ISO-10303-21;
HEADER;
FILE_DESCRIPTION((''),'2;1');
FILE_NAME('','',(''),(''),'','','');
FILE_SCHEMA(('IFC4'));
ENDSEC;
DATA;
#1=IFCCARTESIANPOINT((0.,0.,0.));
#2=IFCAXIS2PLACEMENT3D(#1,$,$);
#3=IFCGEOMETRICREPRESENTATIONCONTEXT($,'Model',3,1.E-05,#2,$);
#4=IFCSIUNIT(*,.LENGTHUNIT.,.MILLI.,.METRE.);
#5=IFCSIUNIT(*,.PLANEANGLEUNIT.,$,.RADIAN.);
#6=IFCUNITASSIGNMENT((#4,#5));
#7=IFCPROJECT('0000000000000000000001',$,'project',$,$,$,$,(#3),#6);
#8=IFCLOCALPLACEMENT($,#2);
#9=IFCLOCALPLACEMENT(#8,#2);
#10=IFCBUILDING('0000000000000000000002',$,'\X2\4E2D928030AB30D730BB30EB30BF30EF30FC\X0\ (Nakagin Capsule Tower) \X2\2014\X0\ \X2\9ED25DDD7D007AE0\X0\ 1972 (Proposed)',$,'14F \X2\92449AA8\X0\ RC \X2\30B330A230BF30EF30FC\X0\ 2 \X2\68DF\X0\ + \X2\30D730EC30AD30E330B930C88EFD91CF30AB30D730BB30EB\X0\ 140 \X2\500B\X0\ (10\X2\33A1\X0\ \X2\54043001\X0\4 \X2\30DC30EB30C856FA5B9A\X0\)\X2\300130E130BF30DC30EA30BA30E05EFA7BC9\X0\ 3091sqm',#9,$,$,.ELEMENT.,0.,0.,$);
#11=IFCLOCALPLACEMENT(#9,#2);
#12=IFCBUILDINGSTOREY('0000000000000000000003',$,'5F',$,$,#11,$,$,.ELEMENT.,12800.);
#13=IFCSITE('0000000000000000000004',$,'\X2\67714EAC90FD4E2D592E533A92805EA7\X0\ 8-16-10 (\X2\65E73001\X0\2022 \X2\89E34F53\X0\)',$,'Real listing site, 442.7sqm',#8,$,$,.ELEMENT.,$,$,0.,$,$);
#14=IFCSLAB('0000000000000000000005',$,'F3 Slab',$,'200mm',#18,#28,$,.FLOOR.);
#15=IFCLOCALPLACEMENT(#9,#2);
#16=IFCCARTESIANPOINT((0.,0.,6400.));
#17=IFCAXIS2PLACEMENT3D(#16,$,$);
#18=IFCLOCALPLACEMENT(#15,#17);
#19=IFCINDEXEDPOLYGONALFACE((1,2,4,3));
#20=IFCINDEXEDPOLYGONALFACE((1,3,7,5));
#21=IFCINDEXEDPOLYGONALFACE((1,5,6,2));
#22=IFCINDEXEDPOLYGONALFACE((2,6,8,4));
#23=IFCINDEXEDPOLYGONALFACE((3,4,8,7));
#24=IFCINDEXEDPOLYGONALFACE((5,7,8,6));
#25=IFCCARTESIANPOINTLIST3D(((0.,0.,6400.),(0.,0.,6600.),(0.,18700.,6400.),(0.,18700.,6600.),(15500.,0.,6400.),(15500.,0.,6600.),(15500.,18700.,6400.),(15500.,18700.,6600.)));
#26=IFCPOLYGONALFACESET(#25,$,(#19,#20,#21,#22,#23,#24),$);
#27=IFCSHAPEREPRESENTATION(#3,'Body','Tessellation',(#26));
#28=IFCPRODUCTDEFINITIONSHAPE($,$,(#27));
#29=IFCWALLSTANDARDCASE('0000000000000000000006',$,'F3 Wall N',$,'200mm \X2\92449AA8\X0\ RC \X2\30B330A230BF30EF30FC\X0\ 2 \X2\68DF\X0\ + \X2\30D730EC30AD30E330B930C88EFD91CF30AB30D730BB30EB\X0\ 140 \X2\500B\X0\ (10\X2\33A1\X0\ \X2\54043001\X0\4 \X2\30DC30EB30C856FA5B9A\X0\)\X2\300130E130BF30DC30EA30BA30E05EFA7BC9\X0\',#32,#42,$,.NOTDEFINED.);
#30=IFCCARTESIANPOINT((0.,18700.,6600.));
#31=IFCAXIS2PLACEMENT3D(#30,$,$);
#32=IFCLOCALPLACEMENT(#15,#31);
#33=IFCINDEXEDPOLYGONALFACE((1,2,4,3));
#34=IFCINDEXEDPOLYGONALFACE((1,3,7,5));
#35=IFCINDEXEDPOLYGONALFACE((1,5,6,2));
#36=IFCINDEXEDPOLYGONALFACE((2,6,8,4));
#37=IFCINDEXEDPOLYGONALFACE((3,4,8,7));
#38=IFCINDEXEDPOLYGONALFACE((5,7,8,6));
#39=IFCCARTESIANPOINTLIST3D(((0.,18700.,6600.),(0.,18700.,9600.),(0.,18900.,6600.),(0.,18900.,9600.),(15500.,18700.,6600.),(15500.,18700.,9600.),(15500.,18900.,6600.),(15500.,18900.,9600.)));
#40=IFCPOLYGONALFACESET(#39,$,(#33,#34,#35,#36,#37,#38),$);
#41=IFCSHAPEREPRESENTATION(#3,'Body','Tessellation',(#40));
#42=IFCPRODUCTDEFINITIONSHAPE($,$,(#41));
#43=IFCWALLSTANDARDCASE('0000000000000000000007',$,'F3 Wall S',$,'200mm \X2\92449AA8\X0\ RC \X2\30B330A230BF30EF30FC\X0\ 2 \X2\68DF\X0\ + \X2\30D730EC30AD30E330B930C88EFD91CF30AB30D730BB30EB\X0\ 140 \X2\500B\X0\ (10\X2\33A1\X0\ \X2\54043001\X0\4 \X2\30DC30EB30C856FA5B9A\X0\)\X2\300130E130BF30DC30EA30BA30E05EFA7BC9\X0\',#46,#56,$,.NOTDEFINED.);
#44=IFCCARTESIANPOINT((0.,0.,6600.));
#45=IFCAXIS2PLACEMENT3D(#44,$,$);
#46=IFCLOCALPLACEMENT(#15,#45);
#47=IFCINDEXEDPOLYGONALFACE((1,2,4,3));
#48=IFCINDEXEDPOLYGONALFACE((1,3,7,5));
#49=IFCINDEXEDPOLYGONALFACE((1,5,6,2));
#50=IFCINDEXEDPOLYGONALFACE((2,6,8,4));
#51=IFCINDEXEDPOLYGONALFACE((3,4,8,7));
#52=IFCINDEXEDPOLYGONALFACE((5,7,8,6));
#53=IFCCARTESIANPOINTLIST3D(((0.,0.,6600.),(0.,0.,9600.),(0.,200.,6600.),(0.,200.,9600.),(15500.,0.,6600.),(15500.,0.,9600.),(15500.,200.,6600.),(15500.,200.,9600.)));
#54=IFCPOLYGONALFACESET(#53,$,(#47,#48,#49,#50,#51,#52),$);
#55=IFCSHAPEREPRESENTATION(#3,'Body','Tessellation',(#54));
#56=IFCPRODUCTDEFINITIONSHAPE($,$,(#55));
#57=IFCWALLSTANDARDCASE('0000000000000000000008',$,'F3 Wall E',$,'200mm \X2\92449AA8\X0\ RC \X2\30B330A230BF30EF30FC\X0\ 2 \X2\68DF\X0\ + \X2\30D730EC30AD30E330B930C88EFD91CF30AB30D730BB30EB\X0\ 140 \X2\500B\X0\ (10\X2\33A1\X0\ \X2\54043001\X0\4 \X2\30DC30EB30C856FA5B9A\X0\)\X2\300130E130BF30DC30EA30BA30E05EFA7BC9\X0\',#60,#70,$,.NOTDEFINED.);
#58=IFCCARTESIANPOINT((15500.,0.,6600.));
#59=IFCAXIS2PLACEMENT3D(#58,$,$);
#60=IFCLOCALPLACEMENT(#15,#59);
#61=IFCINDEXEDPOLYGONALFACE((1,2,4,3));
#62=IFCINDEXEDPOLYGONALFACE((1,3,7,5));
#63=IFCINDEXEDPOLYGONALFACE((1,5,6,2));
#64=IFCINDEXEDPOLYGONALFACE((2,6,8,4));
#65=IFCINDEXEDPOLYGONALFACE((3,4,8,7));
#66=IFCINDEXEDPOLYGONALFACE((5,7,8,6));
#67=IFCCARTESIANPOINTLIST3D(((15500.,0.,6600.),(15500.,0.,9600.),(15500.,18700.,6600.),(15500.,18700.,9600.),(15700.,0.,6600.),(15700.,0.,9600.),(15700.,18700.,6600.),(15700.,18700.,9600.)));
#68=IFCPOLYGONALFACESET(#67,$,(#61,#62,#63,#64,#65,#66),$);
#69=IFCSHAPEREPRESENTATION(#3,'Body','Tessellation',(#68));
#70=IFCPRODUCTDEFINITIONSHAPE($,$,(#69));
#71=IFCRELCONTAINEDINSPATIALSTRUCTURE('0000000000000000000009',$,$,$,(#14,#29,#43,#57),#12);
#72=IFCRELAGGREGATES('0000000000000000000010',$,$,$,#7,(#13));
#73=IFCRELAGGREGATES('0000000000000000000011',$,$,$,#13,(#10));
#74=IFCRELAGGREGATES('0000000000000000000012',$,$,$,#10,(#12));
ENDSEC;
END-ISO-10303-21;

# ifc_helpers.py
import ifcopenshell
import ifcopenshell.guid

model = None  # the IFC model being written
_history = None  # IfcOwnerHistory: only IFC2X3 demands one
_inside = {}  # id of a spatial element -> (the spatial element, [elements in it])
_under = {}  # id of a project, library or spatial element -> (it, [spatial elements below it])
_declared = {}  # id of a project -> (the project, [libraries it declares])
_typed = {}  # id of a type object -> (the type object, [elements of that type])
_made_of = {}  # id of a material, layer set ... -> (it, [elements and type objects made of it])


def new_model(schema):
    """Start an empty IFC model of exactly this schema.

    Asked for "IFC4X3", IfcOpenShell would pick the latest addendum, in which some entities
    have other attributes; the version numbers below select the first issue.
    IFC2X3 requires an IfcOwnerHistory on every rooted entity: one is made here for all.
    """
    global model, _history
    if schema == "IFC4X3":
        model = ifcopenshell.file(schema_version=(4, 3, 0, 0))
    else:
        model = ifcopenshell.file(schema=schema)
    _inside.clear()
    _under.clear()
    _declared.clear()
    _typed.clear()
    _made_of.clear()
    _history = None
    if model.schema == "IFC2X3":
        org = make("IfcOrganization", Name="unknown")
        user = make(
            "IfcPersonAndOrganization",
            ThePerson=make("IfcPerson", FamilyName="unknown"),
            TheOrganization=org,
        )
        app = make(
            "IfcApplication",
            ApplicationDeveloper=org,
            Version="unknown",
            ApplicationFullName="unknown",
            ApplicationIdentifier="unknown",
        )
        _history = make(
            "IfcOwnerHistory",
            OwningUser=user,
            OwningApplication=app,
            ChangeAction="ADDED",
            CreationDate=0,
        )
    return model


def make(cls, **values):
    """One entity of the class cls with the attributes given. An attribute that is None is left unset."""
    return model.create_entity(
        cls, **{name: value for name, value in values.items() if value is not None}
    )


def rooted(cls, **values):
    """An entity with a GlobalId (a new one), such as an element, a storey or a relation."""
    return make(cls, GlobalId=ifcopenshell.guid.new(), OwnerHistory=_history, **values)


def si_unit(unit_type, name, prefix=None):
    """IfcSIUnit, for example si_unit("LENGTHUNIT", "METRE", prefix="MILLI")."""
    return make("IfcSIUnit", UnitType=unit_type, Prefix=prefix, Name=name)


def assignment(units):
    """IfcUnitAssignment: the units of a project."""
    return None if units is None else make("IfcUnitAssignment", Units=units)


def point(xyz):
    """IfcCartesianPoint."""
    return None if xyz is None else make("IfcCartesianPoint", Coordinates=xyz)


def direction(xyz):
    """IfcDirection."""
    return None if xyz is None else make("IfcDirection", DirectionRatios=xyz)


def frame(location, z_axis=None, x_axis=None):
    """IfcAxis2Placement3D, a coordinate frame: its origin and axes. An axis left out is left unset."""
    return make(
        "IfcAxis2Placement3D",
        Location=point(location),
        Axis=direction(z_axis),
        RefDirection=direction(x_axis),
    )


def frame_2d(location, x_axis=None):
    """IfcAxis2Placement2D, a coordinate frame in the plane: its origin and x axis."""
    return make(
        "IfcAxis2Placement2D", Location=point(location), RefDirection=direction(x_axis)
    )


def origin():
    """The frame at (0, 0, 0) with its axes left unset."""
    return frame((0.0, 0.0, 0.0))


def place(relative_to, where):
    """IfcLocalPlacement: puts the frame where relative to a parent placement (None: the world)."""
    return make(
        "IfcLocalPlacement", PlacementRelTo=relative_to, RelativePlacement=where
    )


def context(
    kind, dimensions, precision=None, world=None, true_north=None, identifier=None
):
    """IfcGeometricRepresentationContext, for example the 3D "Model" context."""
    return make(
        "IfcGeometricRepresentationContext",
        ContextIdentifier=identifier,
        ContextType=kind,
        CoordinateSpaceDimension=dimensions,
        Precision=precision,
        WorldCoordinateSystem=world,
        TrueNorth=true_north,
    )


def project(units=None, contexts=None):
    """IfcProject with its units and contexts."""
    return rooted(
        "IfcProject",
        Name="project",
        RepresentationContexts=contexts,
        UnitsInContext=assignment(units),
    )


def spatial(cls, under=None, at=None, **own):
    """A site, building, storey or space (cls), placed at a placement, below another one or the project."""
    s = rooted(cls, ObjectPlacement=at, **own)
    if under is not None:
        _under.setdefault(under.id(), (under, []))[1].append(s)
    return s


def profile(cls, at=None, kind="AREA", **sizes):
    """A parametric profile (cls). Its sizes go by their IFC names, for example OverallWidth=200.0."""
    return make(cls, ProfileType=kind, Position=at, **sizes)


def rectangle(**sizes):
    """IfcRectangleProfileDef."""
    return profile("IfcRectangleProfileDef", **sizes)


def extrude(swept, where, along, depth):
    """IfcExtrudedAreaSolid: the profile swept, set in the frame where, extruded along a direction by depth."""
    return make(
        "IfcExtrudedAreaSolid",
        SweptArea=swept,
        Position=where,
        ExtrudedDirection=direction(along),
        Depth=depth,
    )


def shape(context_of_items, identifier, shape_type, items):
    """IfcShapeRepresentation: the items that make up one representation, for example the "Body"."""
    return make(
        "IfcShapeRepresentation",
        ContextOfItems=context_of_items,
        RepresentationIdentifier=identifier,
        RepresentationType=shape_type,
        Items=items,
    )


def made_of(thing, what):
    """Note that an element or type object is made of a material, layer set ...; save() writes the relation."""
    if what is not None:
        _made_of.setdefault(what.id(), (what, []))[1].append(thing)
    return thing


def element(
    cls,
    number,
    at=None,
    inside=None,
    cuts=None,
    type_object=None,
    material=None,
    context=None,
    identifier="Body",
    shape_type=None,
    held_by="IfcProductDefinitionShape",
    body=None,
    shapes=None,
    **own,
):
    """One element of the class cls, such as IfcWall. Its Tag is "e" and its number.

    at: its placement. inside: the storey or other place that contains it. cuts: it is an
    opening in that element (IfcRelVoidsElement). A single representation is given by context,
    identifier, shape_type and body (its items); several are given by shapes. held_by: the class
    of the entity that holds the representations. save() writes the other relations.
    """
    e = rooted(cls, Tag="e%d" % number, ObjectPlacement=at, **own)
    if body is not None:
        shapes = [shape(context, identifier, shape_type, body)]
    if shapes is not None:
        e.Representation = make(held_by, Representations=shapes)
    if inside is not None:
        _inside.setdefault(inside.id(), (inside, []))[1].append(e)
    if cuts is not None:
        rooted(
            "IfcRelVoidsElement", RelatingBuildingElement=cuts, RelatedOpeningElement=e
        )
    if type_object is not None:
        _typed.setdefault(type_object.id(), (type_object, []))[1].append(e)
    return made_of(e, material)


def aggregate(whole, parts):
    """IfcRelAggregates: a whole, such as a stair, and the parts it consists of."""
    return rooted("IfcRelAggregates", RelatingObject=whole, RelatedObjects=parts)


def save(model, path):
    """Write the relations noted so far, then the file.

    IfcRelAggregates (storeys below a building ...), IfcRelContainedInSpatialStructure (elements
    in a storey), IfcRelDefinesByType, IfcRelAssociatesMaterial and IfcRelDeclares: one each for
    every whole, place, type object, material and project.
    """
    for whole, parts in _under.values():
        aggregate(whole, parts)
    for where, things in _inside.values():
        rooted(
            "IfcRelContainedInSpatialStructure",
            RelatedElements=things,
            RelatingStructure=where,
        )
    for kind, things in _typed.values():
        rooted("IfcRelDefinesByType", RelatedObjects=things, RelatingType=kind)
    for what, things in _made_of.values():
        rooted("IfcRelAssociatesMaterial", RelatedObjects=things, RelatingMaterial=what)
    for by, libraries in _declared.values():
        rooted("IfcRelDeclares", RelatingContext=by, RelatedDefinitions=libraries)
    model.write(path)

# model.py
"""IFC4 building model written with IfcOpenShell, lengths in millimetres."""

from ifc_helpers import new_model, si_unit, frame, frame_2d, origin, place, context, project, spatial, rectangle, extrude, element, save


model = new_model("IFC4")

# Units and contexts
model_context = context("Model", 3, precision=1e-05, world=origin())
ifc_project = project(units=[si_unit("LENGTHUNIT", "METRE", prefix="MILLI"), si_unit("PLANEANGLEUNIT", "RADIAN")], contexts=[model_context])

# Site, building, storey
site_placement = place(None, origin())
site = spatial("IfcSite", under=ifc_project, at=site_placement, Name="東京都中央区銀座 8-16-10 (旧、2022 解体)", ObjectType="Real listing site, 442.7sqm", CompositionType="ELEMENT", RefElevation=0.0)
building_placement = place(site_placement, origin())
building = spatial("IfcBuilding", under=site, at=building_placement, Name="中銀カプセルタワー (Nakagin Capsule Tower) — 黒川紀章 1972 (Proposed)", ObjectType="14F 鉄骨 RC コアタワー 2 棟 + プレキャスト軽量カプセル 140 個 (10㎡ 各、4 ボルト固定)、メタボリズム建築 3091sqm", CompositionType="ELEMENT", ElevationOfRefHeight=0.0, ElevationOfTerrain=0.0)
storey_placement = place(building_placement, origin())
storey = spatial("IfcBuildingStorey", under=building, at=storey_placement, Name="5F", CompositionType="ELEMENT", Elevation=12800.0)

# Slab
placement = place(building_placement, origin())
slab_placement = place(placement, frame((0.0, 0.0, 6400.0)))
element("IfcSlab", 1, at=slab_placement, inside=storey, Name="F3 Slab", ObjectType="200mm", PredefinedType="FLOOR", context=model_context, shape_type="SweptSolid", body=[
    extrude(rectangle(XDim=15500.0, YDim=18700.0, at=frame_2d((7750.0, 9350.0))), frame((0.0, 0.0, 6400.0)), (0.0, 0.0, 1.0), 200.0),
])

# Walls
wall_1_placement = place(placement, frame((0.0, 18700.0, 6600.0)))
element("IfcWallStandardCase", 2, at=wall_1_placement, inside=storey, Name="F3 Wall N", ObjectType="200mm 鉄骨 RC コアタワー 2 棟 + プレキャスト軽量カプセル 140 個 (10㎡ 各、4 ボルト固定)、メタボリズム建築", PredefinedType="NOTDEFINED", context=model_context, shape_type="SweptSolid", body=[
    extrude(rectangle(XDim=15500.0, YDim=200.0, at=frame_2d((7750.0, 100.0))), frame((0.0, 18700.0, 6600.0)), (0.0, 0.0, 1.0), 3000.0),
])
wall_2_placement = place(placement, frame((0.0, 0.0, 6600.0)))
element("IfcWallStandardCase", 3, at=wall_2_placement, inside=storey, Name="F3 Wall S", ObjectType="200mm 鉄骨 RC コアタワー 2 棟 + プレキャスト軽量カプセル 140 個 (10㎡ 各、4 ボルト固定)、メタボリズム建築", PredefinedType="NOTDEFINED", context=model_context, shape_type="SweptSolid", body=[
    extrude(rectangle(XDim=15500.0, YDim=200.0, at=frame_2d((7750.0, 100.0))), frame((0.0, 0.0, 6600.0)), (0.0, 0.0, 1.0), 3000.0),
])
wall_3_placement = place(placement, frame((15500.0, 0.0, 6600.0)))
element("IfcWallStandardCase", 4, at=wall_3_placement, inside=storey, Name="F3 Wall E", ObjectType="200mm 鉄骨 RC コアタワー 2 棟 + プレキャスト軽量カプセル 140 個 (10㎡ 各、4 ボルト固定)、メタボリズム建築", PredefinedType="NOTDEFINED", context=model_context, shape_type="SweptSolid", body=[
    extrude(rectangle(XDim=200.0, YDim=18700.0, at=frame_2d((100.0, 9350.0))), frame((15500.0, 0.0, 6600.0)), (0.0, 0.0, 1.0), 3000.0),
])

save(model, "model.ifc")
